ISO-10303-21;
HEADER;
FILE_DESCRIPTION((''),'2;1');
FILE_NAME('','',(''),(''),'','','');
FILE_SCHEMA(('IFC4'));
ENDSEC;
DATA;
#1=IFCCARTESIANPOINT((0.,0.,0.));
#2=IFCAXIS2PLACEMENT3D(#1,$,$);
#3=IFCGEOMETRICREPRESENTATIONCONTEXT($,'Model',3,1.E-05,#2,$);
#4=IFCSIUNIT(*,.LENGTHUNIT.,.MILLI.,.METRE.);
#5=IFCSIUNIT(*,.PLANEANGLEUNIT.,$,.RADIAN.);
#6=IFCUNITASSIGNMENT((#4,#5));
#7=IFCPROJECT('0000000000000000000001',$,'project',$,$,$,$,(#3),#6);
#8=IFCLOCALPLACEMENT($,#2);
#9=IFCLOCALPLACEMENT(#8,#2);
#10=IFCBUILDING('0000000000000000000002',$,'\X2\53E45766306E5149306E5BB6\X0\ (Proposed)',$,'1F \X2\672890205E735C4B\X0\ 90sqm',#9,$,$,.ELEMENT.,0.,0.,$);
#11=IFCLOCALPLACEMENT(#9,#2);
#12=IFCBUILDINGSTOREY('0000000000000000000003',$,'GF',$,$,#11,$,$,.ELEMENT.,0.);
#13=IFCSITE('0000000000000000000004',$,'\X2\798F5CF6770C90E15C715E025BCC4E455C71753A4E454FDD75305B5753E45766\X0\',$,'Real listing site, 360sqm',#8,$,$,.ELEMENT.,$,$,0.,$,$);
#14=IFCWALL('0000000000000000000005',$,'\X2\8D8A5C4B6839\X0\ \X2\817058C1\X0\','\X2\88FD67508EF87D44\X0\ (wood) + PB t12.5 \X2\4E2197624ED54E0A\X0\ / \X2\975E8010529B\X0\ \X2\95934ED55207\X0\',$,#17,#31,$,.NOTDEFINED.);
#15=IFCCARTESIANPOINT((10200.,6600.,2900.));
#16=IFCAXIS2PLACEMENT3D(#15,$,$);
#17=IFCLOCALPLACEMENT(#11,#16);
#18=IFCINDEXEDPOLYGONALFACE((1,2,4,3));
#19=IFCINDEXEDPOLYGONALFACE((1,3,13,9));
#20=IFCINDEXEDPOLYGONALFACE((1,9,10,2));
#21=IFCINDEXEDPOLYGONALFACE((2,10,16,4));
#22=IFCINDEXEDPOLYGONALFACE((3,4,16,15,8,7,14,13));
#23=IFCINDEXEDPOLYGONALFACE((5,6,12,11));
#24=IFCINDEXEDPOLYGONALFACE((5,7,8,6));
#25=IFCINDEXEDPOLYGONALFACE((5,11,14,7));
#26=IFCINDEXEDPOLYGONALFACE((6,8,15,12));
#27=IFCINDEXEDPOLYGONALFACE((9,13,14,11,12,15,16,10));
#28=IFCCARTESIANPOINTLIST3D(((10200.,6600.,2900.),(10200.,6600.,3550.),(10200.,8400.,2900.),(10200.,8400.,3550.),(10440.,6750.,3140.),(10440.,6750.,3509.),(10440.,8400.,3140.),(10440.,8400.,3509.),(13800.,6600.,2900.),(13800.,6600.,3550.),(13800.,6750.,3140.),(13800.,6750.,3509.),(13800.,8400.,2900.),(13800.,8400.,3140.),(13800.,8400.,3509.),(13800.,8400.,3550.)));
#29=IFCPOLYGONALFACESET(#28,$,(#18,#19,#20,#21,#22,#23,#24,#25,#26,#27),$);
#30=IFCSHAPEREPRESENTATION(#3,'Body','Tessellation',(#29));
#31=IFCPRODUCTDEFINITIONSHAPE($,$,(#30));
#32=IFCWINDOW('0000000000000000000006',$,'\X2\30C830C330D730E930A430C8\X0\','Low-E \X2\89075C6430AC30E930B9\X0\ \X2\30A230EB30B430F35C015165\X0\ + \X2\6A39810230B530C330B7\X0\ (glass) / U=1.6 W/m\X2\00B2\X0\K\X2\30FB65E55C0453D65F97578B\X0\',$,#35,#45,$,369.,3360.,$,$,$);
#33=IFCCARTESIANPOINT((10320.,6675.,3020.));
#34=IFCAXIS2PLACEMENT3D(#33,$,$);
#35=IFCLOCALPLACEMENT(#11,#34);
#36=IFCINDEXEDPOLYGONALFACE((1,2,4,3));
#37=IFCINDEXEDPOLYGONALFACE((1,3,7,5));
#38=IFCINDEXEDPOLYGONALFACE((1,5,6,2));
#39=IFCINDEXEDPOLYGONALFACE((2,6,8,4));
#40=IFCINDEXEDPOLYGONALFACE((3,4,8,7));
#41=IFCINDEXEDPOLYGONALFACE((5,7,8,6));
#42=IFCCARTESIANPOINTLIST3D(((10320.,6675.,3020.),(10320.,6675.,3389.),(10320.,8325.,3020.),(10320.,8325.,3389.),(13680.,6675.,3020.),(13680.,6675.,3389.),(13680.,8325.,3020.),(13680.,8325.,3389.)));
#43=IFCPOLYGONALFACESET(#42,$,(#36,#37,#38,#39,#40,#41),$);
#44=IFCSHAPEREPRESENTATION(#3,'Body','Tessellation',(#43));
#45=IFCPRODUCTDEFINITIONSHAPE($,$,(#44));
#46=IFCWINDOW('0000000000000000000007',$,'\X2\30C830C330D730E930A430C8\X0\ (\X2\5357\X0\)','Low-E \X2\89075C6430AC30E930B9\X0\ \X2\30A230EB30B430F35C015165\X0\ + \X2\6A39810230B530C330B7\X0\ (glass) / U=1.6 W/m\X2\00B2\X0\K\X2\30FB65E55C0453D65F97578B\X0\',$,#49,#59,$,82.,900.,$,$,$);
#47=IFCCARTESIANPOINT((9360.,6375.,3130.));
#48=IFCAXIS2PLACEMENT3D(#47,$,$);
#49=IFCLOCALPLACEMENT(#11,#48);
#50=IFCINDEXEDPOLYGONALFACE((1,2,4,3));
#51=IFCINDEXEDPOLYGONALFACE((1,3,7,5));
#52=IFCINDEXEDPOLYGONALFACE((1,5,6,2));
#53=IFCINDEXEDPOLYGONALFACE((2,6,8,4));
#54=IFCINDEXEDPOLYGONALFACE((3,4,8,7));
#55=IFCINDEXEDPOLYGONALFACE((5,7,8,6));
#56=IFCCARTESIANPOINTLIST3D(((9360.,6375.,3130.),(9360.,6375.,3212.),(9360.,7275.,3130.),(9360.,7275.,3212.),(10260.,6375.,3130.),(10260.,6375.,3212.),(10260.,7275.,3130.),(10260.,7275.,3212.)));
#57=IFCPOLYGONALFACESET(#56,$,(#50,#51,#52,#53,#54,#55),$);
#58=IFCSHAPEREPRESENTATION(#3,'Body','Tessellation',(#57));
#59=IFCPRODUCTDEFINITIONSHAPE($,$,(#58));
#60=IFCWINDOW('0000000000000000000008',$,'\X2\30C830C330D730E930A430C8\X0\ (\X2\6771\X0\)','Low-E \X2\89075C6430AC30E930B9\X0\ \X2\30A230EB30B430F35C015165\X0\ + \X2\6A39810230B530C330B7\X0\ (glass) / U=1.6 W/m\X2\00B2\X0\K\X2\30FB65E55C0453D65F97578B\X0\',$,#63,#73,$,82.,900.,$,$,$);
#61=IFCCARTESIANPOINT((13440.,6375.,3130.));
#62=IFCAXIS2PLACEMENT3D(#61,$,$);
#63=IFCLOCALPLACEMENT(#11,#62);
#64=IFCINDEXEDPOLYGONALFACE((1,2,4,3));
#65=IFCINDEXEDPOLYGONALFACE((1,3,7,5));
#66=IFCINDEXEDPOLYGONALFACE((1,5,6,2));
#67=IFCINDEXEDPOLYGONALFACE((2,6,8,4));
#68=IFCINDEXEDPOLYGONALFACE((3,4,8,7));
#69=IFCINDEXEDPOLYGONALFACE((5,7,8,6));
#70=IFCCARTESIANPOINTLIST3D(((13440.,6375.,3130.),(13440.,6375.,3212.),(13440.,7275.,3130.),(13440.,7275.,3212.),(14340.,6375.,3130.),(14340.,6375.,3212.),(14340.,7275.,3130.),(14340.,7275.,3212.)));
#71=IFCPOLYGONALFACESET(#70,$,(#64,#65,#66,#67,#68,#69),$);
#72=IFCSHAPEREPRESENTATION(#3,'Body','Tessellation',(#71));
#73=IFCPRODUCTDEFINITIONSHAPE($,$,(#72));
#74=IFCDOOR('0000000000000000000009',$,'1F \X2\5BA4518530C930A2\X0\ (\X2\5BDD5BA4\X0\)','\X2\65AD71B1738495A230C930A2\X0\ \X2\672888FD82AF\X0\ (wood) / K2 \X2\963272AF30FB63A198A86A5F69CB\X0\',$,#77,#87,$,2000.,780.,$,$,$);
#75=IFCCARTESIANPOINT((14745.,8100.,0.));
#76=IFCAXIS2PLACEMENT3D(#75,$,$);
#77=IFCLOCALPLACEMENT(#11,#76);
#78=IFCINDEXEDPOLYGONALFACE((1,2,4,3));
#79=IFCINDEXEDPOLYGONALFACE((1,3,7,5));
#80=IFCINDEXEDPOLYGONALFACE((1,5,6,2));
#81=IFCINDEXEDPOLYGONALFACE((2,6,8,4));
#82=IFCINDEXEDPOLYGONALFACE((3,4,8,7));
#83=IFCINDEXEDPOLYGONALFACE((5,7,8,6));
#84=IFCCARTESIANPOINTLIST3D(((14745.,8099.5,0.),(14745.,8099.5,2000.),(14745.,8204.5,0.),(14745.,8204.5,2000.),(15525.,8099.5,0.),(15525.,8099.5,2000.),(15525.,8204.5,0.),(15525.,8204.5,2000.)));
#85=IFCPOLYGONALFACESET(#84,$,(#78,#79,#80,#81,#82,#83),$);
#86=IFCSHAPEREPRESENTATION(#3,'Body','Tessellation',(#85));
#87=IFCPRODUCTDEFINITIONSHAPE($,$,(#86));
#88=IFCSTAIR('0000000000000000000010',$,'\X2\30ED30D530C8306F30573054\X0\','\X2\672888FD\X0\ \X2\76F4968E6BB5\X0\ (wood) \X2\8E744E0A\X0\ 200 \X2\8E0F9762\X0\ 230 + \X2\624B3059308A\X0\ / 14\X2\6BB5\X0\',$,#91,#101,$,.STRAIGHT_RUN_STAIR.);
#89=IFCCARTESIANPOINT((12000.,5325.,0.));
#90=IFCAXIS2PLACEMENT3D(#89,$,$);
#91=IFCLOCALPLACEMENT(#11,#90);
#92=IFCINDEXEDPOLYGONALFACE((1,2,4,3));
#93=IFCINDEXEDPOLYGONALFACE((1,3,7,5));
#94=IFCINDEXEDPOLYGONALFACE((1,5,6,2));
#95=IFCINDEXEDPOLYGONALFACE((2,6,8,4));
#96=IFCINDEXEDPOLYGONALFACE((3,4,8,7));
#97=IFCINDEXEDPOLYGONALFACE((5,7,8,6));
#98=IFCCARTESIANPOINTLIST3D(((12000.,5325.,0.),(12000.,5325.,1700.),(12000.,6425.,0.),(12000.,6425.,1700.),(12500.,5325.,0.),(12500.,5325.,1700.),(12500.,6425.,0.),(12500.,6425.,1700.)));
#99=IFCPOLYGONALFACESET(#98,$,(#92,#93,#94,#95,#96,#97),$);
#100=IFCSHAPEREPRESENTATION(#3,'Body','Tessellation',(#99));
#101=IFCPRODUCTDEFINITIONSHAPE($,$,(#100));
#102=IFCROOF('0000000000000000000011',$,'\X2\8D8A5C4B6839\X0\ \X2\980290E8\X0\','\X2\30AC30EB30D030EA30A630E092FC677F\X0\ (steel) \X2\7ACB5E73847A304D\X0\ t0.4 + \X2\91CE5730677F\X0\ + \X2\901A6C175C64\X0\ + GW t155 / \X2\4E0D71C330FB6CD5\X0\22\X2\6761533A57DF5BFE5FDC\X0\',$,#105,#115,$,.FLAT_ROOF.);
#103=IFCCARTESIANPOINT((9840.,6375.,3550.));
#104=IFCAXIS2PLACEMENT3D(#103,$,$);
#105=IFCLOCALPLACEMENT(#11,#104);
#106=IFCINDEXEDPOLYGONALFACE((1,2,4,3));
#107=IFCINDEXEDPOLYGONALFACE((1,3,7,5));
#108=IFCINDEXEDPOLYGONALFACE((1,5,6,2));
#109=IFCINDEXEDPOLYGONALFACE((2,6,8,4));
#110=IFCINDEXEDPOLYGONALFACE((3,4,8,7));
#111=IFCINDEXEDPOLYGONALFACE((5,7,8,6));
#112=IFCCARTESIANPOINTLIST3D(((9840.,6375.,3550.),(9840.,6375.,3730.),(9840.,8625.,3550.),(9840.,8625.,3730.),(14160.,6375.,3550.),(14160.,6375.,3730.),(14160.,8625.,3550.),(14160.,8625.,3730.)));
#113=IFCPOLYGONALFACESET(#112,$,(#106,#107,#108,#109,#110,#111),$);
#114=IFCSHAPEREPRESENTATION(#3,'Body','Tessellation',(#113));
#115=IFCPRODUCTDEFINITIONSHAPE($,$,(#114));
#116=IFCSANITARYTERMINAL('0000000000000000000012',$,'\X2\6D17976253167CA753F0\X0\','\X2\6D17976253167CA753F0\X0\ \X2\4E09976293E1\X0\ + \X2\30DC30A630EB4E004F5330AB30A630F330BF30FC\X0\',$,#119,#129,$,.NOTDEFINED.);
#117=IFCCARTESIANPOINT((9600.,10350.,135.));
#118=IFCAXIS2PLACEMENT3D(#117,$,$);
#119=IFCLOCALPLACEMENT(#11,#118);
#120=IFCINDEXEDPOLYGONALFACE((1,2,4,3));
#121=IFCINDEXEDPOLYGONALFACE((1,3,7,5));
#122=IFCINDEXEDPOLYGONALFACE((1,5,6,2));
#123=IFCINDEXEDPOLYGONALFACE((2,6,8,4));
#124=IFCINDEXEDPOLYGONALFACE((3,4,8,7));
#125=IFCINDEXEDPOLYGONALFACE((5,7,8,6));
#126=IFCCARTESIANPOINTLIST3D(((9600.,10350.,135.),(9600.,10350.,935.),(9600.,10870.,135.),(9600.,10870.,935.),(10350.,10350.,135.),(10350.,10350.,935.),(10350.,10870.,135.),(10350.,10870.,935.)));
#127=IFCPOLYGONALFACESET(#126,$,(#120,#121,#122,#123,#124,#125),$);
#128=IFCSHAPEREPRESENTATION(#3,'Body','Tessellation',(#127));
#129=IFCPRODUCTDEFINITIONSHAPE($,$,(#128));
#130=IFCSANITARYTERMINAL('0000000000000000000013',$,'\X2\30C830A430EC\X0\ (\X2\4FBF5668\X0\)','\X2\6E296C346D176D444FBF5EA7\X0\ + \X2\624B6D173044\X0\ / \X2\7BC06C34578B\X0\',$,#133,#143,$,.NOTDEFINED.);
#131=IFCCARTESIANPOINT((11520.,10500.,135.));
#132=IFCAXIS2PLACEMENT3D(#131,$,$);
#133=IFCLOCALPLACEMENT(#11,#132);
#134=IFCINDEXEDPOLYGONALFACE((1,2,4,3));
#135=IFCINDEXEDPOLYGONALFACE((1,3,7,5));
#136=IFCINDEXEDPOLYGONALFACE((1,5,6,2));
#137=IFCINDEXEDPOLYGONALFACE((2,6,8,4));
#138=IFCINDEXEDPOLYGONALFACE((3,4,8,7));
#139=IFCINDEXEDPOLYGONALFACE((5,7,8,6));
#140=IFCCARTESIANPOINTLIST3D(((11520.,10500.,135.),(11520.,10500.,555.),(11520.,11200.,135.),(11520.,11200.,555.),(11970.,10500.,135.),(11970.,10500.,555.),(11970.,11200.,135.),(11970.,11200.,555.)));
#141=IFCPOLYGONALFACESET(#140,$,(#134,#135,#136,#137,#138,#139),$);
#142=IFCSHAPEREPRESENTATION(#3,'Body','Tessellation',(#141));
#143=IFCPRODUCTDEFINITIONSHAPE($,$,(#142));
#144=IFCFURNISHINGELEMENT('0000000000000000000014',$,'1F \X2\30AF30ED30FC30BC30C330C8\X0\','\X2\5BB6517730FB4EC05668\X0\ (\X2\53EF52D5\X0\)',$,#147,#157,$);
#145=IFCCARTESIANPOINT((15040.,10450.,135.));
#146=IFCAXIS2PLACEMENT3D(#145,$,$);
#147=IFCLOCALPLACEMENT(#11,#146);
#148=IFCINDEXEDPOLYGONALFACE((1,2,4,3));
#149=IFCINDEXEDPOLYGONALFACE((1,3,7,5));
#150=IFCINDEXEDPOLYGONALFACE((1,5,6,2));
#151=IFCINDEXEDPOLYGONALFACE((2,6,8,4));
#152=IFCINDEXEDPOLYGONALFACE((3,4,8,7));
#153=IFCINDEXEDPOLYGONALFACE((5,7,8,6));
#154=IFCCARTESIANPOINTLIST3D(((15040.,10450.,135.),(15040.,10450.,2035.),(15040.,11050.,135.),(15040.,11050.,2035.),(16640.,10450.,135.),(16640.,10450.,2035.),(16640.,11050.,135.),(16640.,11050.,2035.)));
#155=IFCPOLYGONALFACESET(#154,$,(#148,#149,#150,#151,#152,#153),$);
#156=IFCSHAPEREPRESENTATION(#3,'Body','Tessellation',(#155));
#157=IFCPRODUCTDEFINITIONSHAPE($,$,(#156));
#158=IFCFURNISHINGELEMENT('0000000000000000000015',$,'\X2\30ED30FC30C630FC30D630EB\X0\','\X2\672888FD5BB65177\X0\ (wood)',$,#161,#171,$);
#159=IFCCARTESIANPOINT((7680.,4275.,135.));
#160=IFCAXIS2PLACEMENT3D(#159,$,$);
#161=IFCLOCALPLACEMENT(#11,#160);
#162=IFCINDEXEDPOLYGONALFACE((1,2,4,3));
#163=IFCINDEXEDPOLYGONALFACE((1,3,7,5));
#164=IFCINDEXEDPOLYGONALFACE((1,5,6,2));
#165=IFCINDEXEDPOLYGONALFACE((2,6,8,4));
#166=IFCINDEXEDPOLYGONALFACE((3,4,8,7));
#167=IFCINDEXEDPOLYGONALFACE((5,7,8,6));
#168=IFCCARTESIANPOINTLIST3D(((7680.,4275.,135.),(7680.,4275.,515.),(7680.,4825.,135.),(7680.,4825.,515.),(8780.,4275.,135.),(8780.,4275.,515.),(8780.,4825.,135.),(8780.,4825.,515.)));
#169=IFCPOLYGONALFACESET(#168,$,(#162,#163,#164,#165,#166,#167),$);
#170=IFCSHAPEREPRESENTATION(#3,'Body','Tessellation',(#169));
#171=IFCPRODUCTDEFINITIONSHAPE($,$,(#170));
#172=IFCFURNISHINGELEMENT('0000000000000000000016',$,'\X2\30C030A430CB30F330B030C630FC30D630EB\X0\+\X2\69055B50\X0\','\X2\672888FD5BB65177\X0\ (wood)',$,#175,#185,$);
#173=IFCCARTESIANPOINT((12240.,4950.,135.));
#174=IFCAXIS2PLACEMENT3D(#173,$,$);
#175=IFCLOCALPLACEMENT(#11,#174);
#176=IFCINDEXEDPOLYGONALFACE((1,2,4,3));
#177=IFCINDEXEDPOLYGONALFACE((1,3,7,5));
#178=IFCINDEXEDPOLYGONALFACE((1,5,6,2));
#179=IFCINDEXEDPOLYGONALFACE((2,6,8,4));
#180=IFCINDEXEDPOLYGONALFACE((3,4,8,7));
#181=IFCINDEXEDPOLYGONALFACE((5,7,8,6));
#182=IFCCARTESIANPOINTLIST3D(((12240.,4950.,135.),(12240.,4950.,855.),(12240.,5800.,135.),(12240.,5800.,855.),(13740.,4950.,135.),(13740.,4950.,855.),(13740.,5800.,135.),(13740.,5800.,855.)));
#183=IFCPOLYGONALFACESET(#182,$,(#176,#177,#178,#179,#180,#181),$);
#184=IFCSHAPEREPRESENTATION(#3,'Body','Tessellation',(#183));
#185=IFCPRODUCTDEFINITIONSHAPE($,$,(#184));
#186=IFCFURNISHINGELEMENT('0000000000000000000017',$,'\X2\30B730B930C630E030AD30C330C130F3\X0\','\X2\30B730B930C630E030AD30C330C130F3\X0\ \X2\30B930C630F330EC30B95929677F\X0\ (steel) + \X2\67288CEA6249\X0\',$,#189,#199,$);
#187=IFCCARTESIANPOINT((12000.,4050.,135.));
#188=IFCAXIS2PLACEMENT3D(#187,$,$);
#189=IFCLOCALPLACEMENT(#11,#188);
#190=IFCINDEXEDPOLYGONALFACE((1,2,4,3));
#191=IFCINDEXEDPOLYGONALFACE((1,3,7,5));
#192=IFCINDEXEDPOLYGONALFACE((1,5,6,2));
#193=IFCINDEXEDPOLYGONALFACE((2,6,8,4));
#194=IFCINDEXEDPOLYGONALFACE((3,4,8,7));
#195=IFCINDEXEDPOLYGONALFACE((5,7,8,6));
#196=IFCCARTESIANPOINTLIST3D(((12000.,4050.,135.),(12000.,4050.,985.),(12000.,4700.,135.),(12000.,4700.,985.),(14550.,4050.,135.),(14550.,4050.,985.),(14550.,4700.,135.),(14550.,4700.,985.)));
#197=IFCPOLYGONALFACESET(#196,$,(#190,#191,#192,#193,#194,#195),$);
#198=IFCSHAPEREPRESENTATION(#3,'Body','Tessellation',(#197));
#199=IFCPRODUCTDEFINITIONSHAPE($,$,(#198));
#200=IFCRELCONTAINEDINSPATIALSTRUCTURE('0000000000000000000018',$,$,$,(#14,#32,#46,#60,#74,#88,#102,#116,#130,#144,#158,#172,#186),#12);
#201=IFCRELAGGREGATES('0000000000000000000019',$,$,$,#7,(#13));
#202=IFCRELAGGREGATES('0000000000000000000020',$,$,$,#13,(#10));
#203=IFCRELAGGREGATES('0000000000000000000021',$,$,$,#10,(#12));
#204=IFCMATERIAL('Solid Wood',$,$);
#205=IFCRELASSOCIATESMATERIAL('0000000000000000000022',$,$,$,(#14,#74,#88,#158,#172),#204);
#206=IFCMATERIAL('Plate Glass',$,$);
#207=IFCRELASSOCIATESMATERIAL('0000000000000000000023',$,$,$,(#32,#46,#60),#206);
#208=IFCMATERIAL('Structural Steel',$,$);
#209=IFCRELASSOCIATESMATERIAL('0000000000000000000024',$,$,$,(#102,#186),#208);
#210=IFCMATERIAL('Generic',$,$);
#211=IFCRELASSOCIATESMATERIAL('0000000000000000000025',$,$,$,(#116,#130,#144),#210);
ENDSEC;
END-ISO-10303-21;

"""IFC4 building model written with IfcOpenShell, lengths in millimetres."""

from ifc_helpers import new_model, si_unit, frame, frame_2d, origin, place, context, project, spatial, rectangle, extrude, material, element, fill, save


model = new_model("IFC4")

# Units and contexts
model_context = context("Model", 3, precision=1e-05, world=origin())
ifc_project = project(units=[si_unit("LENGTHUNIT", "METRE", prefix="MILLI"), si_unit("PLANEANGLEUNIT", "RADIAN")], contexts=[model_context])

# Site, building, storey
site_placement = place(None, origin())
site = spatial("IfcSite", under=ifc_project, at=site_placement, Name="福島県郡山市富久山町久保田字古坦", ObjectType="Real listing site, 360sqm", CompositionType="ELEMENT", RefElevation=0.0)
building_placement = place(site_placement, origin())
building = spatial("IfcBuilding", under=site, at=building_placement, Name="古坦の光の家 (Proposed)", ObjectType="1F 木造平屋 90sqm", CompositionType="ELEMENT", ElevationOfRefHeight=0.0, ElevationOfTerrain=0.0)
storey_placement = place(building_placement, origin())
storey = spatial("IfcBuildingStorey", under=building, at=storey_placement, Name="GF", CompositionType="ELEMENT", Elevation=0.0)

# Shared definitions
ifc_material_1 = material(Name="Solid Wood")
ifc_material_2 = material(Name="Plate Glass")

# Wall, openings, windows
wall_1_placement = place(storey_placement, frame((10200.0, 6600.0, 2900.0)))
wall_1 = element("IfcWall", 1, at=wall_1_placement, inside=storey, material=ifc_material_1, Name="越屋根 腰壁", Description="製材軸組 (wood) + PB t12.5 両面仕上 / 非耐力 間仕切", PredefinedType="NOTDEFINED", context=model_context, shape_type="SweptSolid", body=[
    extrude(rectangle(XDim=3600.0, YDim=1800.0, at=frame_2d((1800.0, 900.0))), frame((10200.0, 6600.0, 2900.0)), (0.0, 0.0, 1.0), 650.0),
])
opening_1_placement = place(storey_placement, frame((10320.0, 6675.0, 3020.0)))
opening_1 = element("IfcOpeningElement", 2, at=opening_1_placement, cuts=wall_1, PredefinedType="NOTDEFINED", context=model_context, shape_type="SweptSolid", body=[
    extrude(rectangle(XDim=3360.0, YDim=1650.0, at=frame_2d((1680.0, 825.0))), frame((10320.0, 6675.0, 3020.0)), (0.0, 0.0, 1.0), 369.0),
])
opening_2_placement = place(storey_placement, frame((9360.0, 6375.0, 3130.0)))
opening_2 = element("IfcOpeningElement", 3, at=opening_2_placement, cuts=wall_1, PredefinedType="NOTDEFINED", context=model_context, shape_type="SweptSolid", body=[
    extrude(rectangle(XDim=900.0, YDim=900.0, at=frame_2d((450.0, 450.0))), frame((9360.0, 6375.0, 3130.0)), (0.0, 0.0, 1.0), 82.0),
])
opening_3_placement = place(storey_placement, frame((13440.0, 6375.0, 3130.0)))
opening_3 = element("IfcOpeningElement", 4, at=opening_3_placement, cuts=wall_1, PredefinedType="NOTDEFINED", context=model_context, shape_type="SweptSolid", body=[
    extrude(rectangle(XDim=900.0, YDim=900.0, at=frame_2d((450.0, 450.0))), frame((13440.0, 6375.0, 3130.0)), (0.0, 0.0, 1.0), 82.0),
])
window_1_placement = place(storey_placement, frame((10320.0, 6675.0, 3020.0)))
window_1 = element("IfcWindow", 5, at=window_1_placement, inside=storey, material=ifc_material_2, Name="トップライト", Description="Low-E 複層ガラス アルゴン封入 + 樹脂サッシ (glass) / U=1.6 W/m²K・日射取得型", OverallHeight=369.0, OverallWidth=3360.0, context=model_context, shape_type="SweptSolid", body=[
    extrude(rectangle(XDim=3360.0, YDim=1650.0, at=frame_2d((1680.0, 825.0))), frame((10320.0, 6675.0, 3020.0)), (0.0, 0.0, 1.0), 369.0),
])
fill(opening_1, window_1)
window_2_placement = place(storey_placement, frame((9360.0, 6375.0, 3130.0)))
window_2 = element("IfcWindow", 6, at=window_2_placement, inside=storey, material=ifc_material_2, Name="トップライト (南)", Description="Low-E 複層ガラス アルゴン封入 + 樹脂サッシ (glass) / U=1.6 W/m²K・日射取得型", OverallHeight=82.0, OverallWidth=900.0, context=model_context, shape_type="SweptSolid", body=[
    extrude(rectangle(XDim=900.0, YDim=900.0, at=frame_2d((450.0, 450.0))), frame((9360.0, 6375.0, 3130.0)), (0.0, 0.0, 1.0), 82.0),
])
fill(opening_2, window_2)
window_3_placement = place(storey_placement, frame((13440.0, 6375.0, 3130.0)))
window_3 = element("IfcWindow", 7, at=window_3_placement, inside=storey, material=ifc_material_2, Name="トップライト (東)", Description="Low-E 複層ガラス アルゴン封入 + 樹脂サッシ (glass) / U=1.6 W/m²K・日射取得型", OverallHeight=82.0, OverallWidth=900.0, context=model_context, shape_type="SweptSolid", body=[
    extrude(rectangle(XDim=900.0, YDim=900.0, at=frame_2d((450.0, 450.0))), frame((13440.0, 6375.0, 3130.0)), (0.0, 0.0, 1.0), 82.0),
])
fill(opening_3, window_3)

# Door
door_placement = place(storey_placement, frame((14745.0, 8100.0, 0.0)))
element("IfcDoor", 8, at=door_placement, inside=storey, material=ifc_material_1, Name="1F 室内ドア (寝室)", Description="断熱玄関ドア 木製芯 (wood) / K2 防犯・採風機構", OverallHeight=2000.0, OverallWidth=780.0, context=model_context, shape_type="SweptSolid", body=[
    extrude(rectangle(XDim=780.0, YDim=105.0, at=frame_2d((390.0, 52.0))), frame((14745.0, 8100.0, 0.0)), (0.0, 0.0, 1.0), 2000.0),
])

# Stair
stair_placement = place(storey_placement, frame((12000.0, 5325.0, 0.0)))
element("IfcStair", 9, at=stair_placement, inside=storey, material=ifc_material_1, Name="ロフトはしご", Description="木製 直階段 (wood) 蹴上 200 踏面 230 + 手すり / 14段", PredefinedType="STRAIGHT_RUN_STAIR", context=model_context, shape_type="SweptSolid", body=[
    extrude(rectangle(XDim=500.0, YDim=1100.0, at=frame_2d((250.0, 550.0))), frame((12000.0, 5325.0, 0.0)), (0.0, 0.0, 1.0), 1700.0),
])

# Roof
ifc_material_3 = material(Name="Structural Steel")
roof_placement = place(storey_placement, frame((9840.0, 6375.0, 3550.0)))
element("IfcRoof", 10, at=roof_placement, inside=storey, material=ifc_material_3, Name="越屋根 頂部", Description="ガルバリウム鋼板 (steel) 立平葺き t0.4 + 野地板 + 通気層 + GW t155 / 不燃・法22条区域対応", PredefinedType="FLAT_ROOF", context=model_context, shape_type="SweptSolid", body=[
    extrude(rectangle(XDim=4320.0, YDim=2250.0, at=frame_2d((2160.0, 1125.0))), frame((9840.0, 6375.0, 3550.0)), (0.0, 0.0, 1.0), 180.0),
])

# Sanitary terminals
ifc_material_4 = material(Name="Generic")
sanitary_terminal_1_placement = place(storey_placement, frame((9600.0, 10350.0, 135.0)))
element("IfcSanitaryTerminal", 11, at=sanitary_terminal_1_placement, inside=storey, material=ifc_material_4, Name="洗面化粧台", Description="洗面化粧台 三面鏡 + ボウル一体カウンター", PredefinedType="NOTDEFINED", context=model_context, shape_type="SweptSolid", body=[
    extrude(rectangle(XDim=750.0, YDim=520.0, at=frame_2d((375.0, 260.0))), frame((9600.0, 10350.0, 135.0)), (0.0, 0.0, 1.0), 800.0),
])
sanitary_terminal_2_placement = place(storey_placement, frame((11520.0, 10500.0, 135.0)))
element("IfcSanitaryTerminal", 12, at=sanitary_terminal_2_placement, inside=storey, material=ifc_material_4, Name="トイレ (便器)", Description="温水洗浄便座 + 手洗い / 節水型", PredefinedType="NOTDEFINED", context=model_context, shape_type="SweptSolid", body=[
    extrude(rectangle(XDim=450.0, YDim=700.0, at=frame_2d((225.0, 350.0))), frame((11520.0, 10500.0, 135.0)), (0.0, 0.0, 1.0), 420.0),
])

# Furnishing elements
furnishing_1_placement = place(storey_placement, frame((15040.0, 10450.0, 135.0)))
element("IfcFurnishingElement", 13, at=furnishing_1_placement, inside=storey, material=ifc_material_4, Name="1F クローゼット", Description="家具・什器 (可動)", context=model_context, shape_type="SweptSolid", body=[
    extrude(rectangle(XDim=1600.0, YDim=600.0, at=frame_2d((800.0, 300.0))), frame((15040.0, 10450.0, 135.0)), (0.0, 0.0, 1.0), 1900.0),
])
furnishing_2_placement = place(storey_placement, frame((7680.0, 4275.0, 135.0)))
element("IfcFurnishingElement", 14, at=furnishing_2_placement, inside=storey, material=ifc_material_1, Name="ローテーブル", Description="木製家具 (wood)", context=model_context, shape_type="SweptSolid", body=[
    extrude(rectangle(XDim=1100.0, YDim=550.0, at=frame_2d((550.0, 275.0))), frame((7680.0, 4275.0, 135.0)), (0.0, 0.0, 1.0), 380.0),
])
furnishing_3_placement = place(storey_placement, frame((12240.0, 4950.0, 135.0)))
element("IfcFurnishingElement", 15, at=furnishing_3_placement, inside=storey, material=ifc_material_1, Name="ダイニングテーブル+椅子", Description="木製家具 (wood)", context=model_context, shape_type="SweptSolid", body=[
    extrude(rectangle(XDim=1500.0, YDim=850.0, at=frame_2d((750.0, 425.0))), frame((12240.0, 4950.0, 135.0)), (0.0, 0.0, 1.0), 720.0),
])
furnishing_4_placement = place(storey_placement, frame((12000.0, 4050.0, 135.0)))
element("IfcFurnishingElement", 16, at=furnishing_4_placement, inside=storey, material=ifc_material_3, Name="システムキッチン", Description="システムキッチン ステンレス天板 (steel) + 木質扉", context=model_context, shape_type="SweptSolid", body=[
    extrude(rectangle(XDim=2550.0, YDim=650.0, at=frame_2d((1275.0, 325.0))), frame((12000.0, 4050.0, 135.0)), (0.0, 0.0, 1.0), 850.0),
])

save(model, "model.ifc")
